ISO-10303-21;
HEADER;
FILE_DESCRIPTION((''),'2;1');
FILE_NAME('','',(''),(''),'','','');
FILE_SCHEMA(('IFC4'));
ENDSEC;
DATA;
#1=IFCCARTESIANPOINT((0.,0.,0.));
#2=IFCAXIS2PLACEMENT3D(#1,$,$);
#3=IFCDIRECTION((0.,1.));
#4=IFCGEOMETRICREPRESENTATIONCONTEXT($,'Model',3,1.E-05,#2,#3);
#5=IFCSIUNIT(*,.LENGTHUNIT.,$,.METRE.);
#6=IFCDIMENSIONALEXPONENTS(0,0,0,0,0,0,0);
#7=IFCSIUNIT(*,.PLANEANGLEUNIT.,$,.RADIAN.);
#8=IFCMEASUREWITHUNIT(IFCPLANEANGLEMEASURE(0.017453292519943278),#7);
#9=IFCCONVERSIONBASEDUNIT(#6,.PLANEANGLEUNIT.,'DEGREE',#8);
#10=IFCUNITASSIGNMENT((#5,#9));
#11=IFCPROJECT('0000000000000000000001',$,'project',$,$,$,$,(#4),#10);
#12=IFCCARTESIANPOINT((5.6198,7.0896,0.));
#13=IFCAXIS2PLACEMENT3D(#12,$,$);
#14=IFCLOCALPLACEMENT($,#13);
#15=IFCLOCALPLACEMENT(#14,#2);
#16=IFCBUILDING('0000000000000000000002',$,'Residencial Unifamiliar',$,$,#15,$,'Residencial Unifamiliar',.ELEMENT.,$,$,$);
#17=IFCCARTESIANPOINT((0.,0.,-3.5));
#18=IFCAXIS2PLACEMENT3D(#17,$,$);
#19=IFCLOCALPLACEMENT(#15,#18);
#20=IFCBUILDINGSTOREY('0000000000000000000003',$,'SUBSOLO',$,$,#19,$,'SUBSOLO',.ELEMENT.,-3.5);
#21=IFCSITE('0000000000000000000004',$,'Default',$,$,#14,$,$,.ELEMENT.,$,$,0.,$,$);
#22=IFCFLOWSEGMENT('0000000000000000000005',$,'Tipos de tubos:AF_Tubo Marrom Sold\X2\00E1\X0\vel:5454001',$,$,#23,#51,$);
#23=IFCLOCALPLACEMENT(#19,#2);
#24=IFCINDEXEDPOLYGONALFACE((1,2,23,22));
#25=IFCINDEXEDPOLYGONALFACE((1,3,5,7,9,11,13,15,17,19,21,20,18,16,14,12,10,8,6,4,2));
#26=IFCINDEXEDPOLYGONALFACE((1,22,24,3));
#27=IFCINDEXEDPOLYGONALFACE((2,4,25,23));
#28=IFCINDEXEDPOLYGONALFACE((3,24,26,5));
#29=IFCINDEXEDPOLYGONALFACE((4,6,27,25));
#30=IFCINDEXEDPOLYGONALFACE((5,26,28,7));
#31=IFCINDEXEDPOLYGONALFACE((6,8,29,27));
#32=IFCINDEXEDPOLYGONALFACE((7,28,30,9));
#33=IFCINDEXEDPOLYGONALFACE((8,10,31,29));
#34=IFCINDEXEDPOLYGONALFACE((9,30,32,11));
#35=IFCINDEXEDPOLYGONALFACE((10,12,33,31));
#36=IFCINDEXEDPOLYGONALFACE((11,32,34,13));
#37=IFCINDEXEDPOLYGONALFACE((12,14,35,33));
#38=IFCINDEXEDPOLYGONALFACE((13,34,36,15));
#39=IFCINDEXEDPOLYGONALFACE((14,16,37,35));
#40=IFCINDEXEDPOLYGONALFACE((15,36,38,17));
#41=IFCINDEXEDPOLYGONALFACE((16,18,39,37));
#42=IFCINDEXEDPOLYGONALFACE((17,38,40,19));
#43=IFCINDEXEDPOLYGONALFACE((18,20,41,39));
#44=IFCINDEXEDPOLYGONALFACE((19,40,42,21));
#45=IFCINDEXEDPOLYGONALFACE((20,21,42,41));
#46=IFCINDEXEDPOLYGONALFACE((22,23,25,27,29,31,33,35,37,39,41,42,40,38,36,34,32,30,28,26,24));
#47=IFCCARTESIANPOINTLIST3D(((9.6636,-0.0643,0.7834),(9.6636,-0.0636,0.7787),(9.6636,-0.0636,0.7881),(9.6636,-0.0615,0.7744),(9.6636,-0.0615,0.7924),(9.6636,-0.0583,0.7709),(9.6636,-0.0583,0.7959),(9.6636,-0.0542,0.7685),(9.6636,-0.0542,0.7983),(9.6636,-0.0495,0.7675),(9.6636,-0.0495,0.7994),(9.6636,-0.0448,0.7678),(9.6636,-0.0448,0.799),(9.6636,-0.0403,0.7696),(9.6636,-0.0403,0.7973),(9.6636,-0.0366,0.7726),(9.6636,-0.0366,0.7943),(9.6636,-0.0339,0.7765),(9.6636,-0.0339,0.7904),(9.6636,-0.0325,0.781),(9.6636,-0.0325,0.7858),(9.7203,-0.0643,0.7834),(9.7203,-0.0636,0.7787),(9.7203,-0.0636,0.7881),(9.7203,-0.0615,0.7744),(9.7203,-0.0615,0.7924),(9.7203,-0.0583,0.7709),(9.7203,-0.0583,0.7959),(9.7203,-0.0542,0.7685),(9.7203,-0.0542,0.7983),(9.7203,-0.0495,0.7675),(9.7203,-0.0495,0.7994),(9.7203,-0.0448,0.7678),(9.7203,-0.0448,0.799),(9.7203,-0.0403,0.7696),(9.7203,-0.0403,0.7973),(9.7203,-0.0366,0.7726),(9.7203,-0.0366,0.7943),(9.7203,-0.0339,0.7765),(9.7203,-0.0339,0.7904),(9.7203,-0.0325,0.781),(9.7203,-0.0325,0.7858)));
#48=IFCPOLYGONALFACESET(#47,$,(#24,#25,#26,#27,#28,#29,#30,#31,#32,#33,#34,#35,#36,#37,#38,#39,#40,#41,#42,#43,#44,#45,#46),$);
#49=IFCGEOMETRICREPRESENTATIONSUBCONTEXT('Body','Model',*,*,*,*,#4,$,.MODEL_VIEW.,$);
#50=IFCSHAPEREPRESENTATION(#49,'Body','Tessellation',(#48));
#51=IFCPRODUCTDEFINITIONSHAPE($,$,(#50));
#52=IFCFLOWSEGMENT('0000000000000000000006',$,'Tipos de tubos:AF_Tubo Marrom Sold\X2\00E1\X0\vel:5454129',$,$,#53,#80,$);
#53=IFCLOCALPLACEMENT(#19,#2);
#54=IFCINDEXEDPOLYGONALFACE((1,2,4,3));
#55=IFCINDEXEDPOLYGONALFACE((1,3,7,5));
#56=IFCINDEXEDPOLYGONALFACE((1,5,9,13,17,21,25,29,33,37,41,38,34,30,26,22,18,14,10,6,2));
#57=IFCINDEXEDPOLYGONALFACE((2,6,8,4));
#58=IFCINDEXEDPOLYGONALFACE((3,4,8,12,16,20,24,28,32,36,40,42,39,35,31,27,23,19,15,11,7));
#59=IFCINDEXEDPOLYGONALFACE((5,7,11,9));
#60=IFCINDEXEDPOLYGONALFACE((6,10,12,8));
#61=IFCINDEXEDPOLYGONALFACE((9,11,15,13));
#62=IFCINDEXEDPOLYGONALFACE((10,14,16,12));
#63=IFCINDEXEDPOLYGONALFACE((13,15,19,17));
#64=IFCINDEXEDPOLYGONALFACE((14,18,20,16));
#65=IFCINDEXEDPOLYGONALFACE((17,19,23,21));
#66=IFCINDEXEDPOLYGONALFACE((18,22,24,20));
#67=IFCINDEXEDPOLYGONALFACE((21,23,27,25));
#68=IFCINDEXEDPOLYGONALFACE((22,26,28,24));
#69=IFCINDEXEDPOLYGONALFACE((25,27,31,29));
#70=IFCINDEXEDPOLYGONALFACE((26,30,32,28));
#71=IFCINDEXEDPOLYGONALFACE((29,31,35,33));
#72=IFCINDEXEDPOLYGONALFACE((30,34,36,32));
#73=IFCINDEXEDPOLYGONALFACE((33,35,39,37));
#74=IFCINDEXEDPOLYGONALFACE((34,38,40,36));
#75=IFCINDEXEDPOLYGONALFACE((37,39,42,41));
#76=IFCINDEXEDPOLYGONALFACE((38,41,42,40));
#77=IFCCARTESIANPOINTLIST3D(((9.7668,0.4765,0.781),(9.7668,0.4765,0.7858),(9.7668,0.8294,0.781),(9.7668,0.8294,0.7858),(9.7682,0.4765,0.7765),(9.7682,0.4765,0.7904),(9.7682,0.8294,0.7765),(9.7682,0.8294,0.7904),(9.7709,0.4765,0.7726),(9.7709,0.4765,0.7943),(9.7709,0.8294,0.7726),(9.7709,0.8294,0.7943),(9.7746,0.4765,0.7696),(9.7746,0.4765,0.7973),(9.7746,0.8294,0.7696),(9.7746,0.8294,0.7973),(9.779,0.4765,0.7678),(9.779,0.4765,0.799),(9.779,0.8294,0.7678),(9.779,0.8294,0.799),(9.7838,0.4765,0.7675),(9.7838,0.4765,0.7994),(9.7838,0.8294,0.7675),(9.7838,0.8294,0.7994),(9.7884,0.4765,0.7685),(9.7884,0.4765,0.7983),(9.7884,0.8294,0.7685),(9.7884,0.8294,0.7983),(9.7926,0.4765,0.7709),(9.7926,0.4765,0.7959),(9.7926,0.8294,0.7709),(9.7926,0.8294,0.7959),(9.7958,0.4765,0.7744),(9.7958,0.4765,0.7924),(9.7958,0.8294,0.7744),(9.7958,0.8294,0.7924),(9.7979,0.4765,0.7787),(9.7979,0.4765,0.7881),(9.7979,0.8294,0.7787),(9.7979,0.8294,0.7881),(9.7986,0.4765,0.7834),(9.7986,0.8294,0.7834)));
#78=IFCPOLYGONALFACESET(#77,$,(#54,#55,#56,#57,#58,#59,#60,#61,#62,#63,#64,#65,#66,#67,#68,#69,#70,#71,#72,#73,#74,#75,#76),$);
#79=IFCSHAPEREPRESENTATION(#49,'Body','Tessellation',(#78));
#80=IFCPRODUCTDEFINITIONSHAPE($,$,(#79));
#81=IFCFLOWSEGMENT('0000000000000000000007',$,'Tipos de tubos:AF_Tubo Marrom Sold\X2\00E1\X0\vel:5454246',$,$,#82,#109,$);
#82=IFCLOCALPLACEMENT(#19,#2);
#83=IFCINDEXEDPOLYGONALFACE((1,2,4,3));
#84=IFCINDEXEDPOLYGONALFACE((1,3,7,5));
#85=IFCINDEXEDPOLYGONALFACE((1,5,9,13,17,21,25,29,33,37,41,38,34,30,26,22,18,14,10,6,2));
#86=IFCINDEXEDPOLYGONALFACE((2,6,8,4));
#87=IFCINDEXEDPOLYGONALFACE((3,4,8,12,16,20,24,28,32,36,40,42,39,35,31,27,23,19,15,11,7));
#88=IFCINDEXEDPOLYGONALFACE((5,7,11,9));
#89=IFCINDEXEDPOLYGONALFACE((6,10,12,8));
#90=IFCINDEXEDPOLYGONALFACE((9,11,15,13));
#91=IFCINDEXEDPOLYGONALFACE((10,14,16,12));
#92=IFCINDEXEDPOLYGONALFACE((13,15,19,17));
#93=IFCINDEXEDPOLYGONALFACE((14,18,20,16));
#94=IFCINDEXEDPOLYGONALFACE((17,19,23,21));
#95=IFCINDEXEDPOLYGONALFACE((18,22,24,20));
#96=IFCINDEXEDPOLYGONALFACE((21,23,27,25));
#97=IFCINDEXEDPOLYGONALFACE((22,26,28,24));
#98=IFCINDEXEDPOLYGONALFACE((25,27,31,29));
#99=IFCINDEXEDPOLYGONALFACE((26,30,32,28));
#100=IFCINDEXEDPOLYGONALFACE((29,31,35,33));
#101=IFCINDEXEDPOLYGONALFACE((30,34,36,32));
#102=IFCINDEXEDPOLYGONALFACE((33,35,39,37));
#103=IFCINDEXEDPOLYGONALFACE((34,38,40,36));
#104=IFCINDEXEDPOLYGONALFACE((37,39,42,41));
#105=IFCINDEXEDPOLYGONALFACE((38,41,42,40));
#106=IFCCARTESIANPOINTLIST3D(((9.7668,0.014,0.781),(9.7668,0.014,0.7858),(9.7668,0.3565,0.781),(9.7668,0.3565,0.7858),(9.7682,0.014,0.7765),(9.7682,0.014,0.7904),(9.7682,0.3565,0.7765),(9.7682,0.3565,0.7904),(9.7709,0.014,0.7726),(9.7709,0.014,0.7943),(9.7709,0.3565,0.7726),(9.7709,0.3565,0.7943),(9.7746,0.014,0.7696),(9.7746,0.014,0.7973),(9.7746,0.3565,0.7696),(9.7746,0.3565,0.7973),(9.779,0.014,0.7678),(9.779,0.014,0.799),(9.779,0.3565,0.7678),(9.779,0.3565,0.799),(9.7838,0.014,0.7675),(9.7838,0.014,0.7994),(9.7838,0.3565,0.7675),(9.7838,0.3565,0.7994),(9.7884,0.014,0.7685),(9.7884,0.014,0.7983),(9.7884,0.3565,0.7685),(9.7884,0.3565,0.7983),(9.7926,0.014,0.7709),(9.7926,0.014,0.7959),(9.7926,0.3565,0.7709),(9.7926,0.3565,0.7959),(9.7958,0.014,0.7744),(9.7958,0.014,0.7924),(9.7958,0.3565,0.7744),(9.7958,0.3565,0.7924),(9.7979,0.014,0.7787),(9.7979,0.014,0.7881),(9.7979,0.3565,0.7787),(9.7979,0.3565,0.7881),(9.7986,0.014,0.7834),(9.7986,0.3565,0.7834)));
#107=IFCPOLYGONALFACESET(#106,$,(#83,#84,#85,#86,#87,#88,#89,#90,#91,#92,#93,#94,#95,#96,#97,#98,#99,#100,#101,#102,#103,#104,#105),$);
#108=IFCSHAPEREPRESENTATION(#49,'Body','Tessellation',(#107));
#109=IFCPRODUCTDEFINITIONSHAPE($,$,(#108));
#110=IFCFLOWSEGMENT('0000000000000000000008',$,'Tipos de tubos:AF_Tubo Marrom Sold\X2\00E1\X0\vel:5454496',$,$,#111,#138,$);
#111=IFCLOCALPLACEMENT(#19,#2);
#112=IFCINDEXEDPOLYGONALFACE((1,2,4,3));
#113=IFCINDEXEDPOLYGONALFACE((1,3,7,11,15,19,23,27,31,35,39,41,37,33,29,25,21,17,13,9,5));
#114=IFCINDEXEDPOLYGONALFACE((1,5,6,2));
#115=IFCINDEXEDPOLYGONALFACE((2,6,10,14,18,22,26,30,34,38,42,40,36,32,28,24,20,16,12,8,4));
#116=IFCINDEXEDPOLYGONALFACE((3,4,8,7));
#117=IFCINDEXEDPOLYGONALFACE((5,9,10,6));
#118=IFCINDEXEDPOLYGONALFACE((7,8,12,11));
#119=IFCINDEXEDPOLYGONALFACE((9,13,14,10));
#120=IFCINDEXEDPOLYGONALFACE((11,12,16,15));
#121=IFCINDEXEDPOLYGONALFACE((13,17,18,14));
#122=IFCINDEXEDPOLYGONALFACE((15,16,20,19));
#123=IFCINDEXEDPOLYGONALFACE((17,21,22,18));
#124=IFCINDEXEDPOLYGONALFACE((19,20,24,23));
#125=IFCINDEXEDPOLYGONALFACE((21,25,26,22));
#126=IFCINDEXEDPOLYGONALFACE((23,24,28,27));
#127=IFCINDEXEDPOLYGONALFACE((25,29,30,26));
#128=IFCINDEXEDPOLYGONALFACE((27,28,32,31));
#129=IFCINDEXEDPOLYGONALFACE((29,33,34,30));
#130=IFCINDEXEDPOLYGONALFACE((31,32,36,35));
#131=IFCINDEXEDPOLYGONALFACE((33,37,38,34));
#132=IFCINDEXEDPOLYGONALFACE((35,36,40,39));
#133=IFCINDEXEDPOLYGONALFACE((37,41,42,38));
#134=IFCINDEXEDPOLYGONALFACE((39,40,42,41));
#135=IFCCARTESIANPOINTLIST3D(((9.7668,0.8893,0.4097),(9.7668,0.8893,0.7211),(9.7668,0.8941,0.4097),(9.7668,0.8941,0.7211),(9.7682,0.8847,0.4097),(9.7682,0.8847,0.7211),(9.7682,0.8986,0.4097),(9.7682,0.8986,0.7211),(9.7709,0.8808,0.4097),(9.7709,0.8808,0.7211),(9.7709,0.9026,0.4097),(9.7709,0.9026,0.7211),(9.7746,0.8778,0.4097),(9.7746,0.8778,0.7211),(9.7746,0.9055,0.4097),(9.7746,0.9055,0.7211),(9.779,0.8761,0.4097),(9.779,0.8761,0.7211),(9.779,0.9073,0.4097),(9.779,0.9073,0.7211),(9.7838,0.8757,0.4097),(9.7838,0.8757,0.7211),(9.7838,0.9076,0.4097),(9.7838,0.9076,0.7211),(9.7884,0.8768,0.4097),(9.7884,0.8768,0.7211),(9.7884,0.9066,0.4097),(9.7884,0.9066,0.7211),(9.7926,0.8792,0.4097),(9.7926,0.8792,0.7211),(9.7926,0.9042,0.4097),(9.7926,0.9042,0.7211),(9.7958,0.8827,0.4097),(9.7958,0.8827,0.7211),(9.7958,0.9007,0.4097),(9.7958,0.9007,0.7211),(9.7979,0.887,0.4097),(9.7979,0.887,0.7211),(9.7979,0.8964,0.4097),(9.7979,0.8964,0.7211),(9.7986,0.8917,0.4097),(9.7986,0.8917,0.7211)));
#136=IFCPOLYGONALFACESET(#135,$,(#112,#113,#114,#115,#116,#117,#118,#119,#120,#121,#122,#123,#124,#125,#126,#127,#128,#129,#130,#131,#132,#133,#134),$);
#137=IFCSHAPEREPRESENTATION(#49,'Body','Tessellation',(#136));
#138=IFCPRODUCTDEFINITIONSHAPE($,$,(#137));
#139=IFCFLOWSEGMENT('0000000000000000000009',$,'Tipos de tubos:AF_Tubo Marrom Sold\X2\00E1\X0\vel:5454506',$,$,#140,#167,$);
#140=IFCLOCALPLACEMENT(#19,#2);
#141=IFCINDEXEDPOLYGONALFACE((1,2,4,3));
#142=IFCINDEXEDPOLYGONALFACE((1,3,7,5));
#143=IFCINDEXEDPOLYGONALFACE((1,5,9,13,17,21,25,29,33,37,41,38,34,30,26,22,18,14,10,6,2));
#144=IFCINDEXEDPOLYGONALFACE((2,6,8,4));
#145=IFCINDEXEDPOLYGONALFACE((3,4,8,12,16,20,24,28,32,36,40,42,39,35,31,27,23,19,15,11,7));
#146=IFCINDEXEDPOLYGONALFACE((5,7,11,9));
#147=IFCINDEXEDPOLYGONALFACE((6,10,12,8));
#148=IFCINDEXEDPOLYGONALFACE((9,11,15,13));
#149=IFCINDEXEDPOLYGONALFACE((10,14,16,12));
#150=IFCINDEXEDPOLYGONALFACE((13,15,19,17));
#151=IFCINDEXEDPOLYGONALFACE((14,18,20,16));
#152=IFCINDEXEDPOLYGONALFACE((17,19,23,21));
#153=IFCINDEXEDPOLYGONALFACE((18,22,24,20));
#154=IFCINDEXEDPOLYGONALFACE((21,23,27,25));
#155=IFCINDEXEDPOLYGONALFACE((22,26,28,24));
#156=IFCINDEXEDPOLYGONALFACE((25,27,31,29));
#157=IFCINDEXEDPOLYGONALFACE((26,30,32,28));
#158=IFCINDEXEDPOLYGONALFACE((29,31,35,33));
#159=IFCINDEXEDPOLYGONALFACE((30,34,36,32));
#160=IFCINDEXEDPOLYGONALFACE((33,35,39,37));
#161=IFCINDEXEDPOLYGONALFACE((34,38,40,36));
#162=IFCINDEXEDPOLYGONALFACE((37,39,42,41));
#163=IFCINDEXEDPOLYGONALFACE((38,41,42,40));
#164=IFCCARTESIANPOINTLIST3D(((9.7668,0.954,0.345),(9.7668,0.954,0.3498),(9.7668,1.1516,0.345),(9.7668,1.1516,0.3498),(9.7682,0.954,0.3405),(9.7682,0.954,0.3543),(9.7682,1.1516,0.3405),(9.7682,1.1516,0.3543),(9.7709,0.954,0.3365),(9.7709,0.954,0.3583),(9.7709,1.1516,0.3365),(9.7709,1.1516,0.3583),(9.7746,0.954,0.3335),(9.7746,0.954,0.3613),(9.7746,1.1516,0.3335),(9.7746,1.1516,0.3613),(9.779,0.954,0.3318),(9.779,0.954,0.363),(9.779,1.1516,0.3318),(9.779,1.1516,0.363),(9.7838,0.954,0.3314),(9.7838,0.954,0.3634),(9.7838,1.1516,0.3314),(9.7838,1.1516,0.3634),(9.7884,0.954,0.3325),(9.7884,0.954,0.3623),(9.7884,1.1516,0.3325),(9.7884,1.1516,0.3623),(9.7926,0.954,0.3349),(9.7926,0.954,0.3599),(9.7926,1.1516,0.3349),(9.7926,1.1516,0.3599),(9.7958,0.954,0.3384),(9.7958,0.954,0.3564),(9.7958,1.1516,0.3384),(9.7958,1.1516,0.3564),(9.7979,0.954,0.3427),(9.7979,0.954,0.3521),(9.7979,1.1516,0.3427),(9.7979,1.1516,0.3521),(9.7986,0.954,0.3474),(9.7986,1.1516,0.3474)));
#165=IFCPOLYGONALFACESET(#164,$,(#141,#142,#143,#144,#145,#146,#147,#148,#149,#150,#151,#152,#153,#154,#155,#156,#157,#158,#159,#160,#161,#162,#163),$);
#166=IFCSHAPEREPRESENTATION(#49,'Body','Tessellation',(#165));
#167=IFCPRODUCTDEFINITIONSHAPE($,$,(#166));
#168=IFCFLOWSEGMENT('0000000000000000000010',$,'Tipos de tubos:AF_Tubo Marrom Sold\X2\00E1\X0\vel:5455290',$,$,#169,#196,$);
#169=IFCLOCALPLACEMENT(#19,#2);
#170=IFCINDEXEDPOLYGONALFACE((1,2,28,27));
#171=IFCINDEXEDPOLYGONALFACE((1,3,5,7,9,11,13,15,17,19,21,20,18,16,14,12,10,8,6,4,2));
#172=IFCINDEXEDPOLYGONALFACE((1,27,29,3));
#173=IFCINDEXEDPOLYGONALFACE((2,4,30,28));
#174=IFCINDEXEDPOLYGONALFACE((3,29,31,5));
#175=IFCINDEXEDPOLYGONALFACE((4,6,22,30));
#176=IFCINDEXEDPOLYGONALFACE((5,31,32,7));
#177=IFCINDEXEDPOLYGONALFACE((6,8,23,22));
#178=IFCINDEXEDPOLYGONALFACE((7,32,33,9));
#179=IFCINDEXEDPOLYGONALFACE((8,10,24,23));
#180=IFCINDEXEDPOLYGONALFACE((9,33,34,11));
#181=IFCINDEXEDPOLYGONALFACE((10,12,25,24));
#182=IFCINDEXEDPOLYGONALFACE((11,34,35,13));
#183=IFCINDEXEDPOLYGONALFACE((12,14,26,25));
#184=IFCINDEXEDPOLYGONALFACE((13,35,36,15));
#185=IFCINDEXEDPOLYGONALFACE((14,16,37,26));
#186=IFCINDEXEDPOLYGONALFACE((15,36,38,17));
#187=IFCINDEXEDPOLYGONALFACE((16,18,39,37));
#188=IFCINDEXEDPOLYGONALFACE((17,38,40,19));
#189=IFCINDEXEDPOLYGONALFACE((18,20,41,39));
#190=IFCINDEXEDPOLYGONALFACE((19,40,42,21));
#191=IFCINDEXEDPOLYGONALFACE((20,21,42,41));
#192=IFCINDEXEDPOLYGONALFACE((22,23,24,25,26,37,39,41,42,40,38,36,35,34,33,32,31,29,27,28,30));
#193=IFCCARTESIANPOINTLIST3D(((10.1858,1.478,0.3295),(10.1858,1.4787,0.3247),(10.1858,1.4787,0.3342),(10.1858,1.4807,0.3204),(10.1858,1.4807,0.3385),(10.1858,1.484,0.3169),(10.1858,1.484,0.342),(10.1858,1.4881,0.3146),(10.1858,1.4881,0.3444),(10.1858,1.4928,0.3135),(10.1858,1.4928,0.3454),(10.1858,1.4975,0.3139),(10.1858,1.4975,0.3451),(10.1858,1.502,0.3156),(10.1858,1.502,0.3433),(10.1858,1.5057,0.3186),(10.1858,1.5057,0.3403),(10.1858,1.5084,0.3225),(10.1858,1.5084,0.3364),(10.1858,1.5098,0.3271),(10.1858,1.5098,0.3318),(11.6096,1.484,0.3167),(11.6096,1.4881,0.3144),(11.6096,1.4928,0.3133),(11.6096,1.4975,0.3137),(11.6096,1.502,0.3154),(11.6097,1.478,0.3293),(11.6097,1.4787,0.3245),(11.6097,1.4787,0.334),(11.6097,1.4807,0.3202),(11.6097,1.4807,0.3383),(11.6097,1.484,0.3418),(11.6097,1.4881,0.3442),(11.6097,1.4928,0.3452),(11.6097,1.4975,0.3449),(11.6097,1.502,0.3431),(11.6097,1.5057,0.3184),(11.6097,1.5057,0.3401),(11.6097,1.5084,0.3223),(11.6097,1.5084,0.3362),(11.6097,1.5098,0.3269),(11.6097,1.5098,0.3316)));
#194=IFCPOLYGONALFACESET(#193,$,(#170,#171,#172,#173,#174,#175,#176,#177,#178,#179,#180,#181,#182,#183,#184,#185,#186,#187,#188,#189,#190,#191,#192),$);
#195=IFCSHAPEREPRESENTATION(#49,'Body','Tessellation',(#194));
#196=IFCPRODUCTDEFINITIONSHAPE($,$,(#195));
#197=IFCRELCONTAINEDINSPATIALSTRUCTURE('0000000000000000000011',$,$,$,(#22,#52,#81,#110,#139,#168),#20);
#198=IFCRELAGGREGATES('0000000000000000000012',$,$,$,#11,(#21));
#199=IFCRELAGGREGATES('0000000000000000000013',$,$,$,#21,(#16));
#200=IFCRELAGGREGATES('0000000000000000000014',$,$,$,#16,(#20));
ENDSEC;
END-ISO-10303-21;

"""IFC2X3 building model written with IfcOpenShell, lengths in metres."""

from ifc_helpers import new_model, entity, si_unit, converted_unit, direction, frame, frame_2d, origin, origin_2d_with_axis, place, context, subcontext, project, spatial, circle, extrude, element, save


model = new_model("IFC2X3")

# Units and contexts
model_context = context("Model", 3, precision=1e-05, world=origin(), true_north=direction((0.0, 1.0)))
body_context = subcontext(model_context, "Body", "Model", "MODEL_VIEW")
ifc_project = project(units=[si_unit("LENGTHUNIT", "METRE"), converted_unit("PLANEANGLEUNIT", "DEGREE", entity("IfcPlaneAngleMeasure", 0.017453292519943278), si_unit("PLANEANGLEUNIT", "RADIAN"), dimensions=[0, 0, 0, 0, 0, 0, 0])], contexts=[model_context])

# Site, building, storey
site_placement = place(None, frame((5.6198, 7.0896, 0.0)))
site = spatial("IfcSite", under=ifc_project, at=site_placement, Name="Default", CompositionType="ELEMENT", RefElevation=0.0)
building_placement = place(site_placement, origin())
building = spatial("IfcBuilding", under=site, at=building_placement, Name="Residencial Unifamiliar", LongName="Residencial Unifamiliar", CompositionType="ELEMENT")
storey_placement = place(building_placement, frame((0.0, 0.0, -3.5)))
storey = spatial("IfcBuildingStorey", under=building, at=storey_placement, Name="SUBSOLO", LongName="SUBSOLO", CompositionType="ELEMENT", Elevation=-3.5)

# Flow segments
flow_segment_1_placement = place(storey_placement, origin())
element("IfcFlowSegment", 1, at=flow_segment_1_placement, inside=storey, Name="Tipos de tubos:AF_Tubo Marrom Soldável:5454001", context=body_context, shape_type="SweptSolid", body=[
    extrude(circle(Radius=0.016, at=frame_2d((0.0, 0.0), x_axis=(1.0, 0.0))), frame((9.6636, -0.0483, 0.7834), z_axis=(1.0, 0.0, 0.0), x_axis=(0.0, -1.0, 0.0)), (0.0, 0.0, 1.0), 0.0567),
])
flow_segment_2_placement = place(storey_placement, origin())
element("IfcFlowSegment", 2, at=flow_segment_2_placement, inside=storey, Name="Tipos de tubos:AF_Tubo Marrom Soldável:5454129", context=body_context, shape_type="SweptSolid", body=[
    extrude(circle(Radius=0.016, at=origin_2d_with_axis()), frame((9.7826, 0.4765, 0.7834), z_axis=(0.0, 1.0, 0.0), x_axis=(1.0, 0.0, 0.0)), (0.0, 0.0, 1.0), 0.3529),
])
flow_segment_3_placement = place(storey_placement, origin())
element("IfcFlowSegment", 3, at=flow_segment_3_placement, inside=storey, Name="Tipos de tubos:AF_Tubo Marrom Soldável:5454246", context=body_context, shape_type="SweptSolid", body=[
    extrude(circle(Radius=0.016, at=origin_2d_with_axis()), frame((9.7826, 0.014, 0.7834), z_axis=(0.0, 1.0, 0.0), x_axis=(1.0, 0.0, 0.0)), (0.0, 0.0, 1.0), 0.3425),
])
flow_segment_4_placement = place(storey_placement, origin())
element("IfcFlowSegment", 4, at=flow_segment_4_placement, inside=storey, Name="Tipos de tubos:AF_Tubo Marrom Soldável:5454496", context=body_context, shape_type="SweptSolid", body=[
    extrude(circle(Radius=0.016, at=origin_2d_with_axis()), frame((9.7826, 0.8917, 0.4097)), (0.0, 0.0, 1.0), 0.3114),
])
flow_segment_5_placement = place(storey_placement, origin())
element("IfcFlowSegment", 5, at=flow_segment_5_placement, inside=storey, Name="Tipos de tubos:AF_Tubo Marrom Soldável:5454506", context=body_context, shape_type="SweptSolid", body=[
    extrude(circle(Radius=0.016, at=origin_2d_with_axis()), frame((9.7826, 0.954, 0.3474), z_axis=(0.0, 1.0, 0.0), x_axis=(1.0, 0.0, 0.0)), (0.0, 0.0, 1.0), 0.1976),
])
flow_segment_6_placement = place(storey_placement, origin())
element("IfcFlowSegment", 6, at=flow_segment_6_placement, inside=storey, Name="Tipos de tubos:AF_Tubo Marrom Soldável:5455290", context=body_context, shape_type="SweptSolid", body=[
    extrude(circle(Radius=0.016, at=origin_2d_with_axis()), frame((11.6097, 1.494, 0.3293), z_axis=(-1.0, 0.0, 0.000141), x_axis=(0.0, -1.0, 0.0)), (0.0, 0.0, 1.0), 1.4239),
])

save(model, "model.ifc")
